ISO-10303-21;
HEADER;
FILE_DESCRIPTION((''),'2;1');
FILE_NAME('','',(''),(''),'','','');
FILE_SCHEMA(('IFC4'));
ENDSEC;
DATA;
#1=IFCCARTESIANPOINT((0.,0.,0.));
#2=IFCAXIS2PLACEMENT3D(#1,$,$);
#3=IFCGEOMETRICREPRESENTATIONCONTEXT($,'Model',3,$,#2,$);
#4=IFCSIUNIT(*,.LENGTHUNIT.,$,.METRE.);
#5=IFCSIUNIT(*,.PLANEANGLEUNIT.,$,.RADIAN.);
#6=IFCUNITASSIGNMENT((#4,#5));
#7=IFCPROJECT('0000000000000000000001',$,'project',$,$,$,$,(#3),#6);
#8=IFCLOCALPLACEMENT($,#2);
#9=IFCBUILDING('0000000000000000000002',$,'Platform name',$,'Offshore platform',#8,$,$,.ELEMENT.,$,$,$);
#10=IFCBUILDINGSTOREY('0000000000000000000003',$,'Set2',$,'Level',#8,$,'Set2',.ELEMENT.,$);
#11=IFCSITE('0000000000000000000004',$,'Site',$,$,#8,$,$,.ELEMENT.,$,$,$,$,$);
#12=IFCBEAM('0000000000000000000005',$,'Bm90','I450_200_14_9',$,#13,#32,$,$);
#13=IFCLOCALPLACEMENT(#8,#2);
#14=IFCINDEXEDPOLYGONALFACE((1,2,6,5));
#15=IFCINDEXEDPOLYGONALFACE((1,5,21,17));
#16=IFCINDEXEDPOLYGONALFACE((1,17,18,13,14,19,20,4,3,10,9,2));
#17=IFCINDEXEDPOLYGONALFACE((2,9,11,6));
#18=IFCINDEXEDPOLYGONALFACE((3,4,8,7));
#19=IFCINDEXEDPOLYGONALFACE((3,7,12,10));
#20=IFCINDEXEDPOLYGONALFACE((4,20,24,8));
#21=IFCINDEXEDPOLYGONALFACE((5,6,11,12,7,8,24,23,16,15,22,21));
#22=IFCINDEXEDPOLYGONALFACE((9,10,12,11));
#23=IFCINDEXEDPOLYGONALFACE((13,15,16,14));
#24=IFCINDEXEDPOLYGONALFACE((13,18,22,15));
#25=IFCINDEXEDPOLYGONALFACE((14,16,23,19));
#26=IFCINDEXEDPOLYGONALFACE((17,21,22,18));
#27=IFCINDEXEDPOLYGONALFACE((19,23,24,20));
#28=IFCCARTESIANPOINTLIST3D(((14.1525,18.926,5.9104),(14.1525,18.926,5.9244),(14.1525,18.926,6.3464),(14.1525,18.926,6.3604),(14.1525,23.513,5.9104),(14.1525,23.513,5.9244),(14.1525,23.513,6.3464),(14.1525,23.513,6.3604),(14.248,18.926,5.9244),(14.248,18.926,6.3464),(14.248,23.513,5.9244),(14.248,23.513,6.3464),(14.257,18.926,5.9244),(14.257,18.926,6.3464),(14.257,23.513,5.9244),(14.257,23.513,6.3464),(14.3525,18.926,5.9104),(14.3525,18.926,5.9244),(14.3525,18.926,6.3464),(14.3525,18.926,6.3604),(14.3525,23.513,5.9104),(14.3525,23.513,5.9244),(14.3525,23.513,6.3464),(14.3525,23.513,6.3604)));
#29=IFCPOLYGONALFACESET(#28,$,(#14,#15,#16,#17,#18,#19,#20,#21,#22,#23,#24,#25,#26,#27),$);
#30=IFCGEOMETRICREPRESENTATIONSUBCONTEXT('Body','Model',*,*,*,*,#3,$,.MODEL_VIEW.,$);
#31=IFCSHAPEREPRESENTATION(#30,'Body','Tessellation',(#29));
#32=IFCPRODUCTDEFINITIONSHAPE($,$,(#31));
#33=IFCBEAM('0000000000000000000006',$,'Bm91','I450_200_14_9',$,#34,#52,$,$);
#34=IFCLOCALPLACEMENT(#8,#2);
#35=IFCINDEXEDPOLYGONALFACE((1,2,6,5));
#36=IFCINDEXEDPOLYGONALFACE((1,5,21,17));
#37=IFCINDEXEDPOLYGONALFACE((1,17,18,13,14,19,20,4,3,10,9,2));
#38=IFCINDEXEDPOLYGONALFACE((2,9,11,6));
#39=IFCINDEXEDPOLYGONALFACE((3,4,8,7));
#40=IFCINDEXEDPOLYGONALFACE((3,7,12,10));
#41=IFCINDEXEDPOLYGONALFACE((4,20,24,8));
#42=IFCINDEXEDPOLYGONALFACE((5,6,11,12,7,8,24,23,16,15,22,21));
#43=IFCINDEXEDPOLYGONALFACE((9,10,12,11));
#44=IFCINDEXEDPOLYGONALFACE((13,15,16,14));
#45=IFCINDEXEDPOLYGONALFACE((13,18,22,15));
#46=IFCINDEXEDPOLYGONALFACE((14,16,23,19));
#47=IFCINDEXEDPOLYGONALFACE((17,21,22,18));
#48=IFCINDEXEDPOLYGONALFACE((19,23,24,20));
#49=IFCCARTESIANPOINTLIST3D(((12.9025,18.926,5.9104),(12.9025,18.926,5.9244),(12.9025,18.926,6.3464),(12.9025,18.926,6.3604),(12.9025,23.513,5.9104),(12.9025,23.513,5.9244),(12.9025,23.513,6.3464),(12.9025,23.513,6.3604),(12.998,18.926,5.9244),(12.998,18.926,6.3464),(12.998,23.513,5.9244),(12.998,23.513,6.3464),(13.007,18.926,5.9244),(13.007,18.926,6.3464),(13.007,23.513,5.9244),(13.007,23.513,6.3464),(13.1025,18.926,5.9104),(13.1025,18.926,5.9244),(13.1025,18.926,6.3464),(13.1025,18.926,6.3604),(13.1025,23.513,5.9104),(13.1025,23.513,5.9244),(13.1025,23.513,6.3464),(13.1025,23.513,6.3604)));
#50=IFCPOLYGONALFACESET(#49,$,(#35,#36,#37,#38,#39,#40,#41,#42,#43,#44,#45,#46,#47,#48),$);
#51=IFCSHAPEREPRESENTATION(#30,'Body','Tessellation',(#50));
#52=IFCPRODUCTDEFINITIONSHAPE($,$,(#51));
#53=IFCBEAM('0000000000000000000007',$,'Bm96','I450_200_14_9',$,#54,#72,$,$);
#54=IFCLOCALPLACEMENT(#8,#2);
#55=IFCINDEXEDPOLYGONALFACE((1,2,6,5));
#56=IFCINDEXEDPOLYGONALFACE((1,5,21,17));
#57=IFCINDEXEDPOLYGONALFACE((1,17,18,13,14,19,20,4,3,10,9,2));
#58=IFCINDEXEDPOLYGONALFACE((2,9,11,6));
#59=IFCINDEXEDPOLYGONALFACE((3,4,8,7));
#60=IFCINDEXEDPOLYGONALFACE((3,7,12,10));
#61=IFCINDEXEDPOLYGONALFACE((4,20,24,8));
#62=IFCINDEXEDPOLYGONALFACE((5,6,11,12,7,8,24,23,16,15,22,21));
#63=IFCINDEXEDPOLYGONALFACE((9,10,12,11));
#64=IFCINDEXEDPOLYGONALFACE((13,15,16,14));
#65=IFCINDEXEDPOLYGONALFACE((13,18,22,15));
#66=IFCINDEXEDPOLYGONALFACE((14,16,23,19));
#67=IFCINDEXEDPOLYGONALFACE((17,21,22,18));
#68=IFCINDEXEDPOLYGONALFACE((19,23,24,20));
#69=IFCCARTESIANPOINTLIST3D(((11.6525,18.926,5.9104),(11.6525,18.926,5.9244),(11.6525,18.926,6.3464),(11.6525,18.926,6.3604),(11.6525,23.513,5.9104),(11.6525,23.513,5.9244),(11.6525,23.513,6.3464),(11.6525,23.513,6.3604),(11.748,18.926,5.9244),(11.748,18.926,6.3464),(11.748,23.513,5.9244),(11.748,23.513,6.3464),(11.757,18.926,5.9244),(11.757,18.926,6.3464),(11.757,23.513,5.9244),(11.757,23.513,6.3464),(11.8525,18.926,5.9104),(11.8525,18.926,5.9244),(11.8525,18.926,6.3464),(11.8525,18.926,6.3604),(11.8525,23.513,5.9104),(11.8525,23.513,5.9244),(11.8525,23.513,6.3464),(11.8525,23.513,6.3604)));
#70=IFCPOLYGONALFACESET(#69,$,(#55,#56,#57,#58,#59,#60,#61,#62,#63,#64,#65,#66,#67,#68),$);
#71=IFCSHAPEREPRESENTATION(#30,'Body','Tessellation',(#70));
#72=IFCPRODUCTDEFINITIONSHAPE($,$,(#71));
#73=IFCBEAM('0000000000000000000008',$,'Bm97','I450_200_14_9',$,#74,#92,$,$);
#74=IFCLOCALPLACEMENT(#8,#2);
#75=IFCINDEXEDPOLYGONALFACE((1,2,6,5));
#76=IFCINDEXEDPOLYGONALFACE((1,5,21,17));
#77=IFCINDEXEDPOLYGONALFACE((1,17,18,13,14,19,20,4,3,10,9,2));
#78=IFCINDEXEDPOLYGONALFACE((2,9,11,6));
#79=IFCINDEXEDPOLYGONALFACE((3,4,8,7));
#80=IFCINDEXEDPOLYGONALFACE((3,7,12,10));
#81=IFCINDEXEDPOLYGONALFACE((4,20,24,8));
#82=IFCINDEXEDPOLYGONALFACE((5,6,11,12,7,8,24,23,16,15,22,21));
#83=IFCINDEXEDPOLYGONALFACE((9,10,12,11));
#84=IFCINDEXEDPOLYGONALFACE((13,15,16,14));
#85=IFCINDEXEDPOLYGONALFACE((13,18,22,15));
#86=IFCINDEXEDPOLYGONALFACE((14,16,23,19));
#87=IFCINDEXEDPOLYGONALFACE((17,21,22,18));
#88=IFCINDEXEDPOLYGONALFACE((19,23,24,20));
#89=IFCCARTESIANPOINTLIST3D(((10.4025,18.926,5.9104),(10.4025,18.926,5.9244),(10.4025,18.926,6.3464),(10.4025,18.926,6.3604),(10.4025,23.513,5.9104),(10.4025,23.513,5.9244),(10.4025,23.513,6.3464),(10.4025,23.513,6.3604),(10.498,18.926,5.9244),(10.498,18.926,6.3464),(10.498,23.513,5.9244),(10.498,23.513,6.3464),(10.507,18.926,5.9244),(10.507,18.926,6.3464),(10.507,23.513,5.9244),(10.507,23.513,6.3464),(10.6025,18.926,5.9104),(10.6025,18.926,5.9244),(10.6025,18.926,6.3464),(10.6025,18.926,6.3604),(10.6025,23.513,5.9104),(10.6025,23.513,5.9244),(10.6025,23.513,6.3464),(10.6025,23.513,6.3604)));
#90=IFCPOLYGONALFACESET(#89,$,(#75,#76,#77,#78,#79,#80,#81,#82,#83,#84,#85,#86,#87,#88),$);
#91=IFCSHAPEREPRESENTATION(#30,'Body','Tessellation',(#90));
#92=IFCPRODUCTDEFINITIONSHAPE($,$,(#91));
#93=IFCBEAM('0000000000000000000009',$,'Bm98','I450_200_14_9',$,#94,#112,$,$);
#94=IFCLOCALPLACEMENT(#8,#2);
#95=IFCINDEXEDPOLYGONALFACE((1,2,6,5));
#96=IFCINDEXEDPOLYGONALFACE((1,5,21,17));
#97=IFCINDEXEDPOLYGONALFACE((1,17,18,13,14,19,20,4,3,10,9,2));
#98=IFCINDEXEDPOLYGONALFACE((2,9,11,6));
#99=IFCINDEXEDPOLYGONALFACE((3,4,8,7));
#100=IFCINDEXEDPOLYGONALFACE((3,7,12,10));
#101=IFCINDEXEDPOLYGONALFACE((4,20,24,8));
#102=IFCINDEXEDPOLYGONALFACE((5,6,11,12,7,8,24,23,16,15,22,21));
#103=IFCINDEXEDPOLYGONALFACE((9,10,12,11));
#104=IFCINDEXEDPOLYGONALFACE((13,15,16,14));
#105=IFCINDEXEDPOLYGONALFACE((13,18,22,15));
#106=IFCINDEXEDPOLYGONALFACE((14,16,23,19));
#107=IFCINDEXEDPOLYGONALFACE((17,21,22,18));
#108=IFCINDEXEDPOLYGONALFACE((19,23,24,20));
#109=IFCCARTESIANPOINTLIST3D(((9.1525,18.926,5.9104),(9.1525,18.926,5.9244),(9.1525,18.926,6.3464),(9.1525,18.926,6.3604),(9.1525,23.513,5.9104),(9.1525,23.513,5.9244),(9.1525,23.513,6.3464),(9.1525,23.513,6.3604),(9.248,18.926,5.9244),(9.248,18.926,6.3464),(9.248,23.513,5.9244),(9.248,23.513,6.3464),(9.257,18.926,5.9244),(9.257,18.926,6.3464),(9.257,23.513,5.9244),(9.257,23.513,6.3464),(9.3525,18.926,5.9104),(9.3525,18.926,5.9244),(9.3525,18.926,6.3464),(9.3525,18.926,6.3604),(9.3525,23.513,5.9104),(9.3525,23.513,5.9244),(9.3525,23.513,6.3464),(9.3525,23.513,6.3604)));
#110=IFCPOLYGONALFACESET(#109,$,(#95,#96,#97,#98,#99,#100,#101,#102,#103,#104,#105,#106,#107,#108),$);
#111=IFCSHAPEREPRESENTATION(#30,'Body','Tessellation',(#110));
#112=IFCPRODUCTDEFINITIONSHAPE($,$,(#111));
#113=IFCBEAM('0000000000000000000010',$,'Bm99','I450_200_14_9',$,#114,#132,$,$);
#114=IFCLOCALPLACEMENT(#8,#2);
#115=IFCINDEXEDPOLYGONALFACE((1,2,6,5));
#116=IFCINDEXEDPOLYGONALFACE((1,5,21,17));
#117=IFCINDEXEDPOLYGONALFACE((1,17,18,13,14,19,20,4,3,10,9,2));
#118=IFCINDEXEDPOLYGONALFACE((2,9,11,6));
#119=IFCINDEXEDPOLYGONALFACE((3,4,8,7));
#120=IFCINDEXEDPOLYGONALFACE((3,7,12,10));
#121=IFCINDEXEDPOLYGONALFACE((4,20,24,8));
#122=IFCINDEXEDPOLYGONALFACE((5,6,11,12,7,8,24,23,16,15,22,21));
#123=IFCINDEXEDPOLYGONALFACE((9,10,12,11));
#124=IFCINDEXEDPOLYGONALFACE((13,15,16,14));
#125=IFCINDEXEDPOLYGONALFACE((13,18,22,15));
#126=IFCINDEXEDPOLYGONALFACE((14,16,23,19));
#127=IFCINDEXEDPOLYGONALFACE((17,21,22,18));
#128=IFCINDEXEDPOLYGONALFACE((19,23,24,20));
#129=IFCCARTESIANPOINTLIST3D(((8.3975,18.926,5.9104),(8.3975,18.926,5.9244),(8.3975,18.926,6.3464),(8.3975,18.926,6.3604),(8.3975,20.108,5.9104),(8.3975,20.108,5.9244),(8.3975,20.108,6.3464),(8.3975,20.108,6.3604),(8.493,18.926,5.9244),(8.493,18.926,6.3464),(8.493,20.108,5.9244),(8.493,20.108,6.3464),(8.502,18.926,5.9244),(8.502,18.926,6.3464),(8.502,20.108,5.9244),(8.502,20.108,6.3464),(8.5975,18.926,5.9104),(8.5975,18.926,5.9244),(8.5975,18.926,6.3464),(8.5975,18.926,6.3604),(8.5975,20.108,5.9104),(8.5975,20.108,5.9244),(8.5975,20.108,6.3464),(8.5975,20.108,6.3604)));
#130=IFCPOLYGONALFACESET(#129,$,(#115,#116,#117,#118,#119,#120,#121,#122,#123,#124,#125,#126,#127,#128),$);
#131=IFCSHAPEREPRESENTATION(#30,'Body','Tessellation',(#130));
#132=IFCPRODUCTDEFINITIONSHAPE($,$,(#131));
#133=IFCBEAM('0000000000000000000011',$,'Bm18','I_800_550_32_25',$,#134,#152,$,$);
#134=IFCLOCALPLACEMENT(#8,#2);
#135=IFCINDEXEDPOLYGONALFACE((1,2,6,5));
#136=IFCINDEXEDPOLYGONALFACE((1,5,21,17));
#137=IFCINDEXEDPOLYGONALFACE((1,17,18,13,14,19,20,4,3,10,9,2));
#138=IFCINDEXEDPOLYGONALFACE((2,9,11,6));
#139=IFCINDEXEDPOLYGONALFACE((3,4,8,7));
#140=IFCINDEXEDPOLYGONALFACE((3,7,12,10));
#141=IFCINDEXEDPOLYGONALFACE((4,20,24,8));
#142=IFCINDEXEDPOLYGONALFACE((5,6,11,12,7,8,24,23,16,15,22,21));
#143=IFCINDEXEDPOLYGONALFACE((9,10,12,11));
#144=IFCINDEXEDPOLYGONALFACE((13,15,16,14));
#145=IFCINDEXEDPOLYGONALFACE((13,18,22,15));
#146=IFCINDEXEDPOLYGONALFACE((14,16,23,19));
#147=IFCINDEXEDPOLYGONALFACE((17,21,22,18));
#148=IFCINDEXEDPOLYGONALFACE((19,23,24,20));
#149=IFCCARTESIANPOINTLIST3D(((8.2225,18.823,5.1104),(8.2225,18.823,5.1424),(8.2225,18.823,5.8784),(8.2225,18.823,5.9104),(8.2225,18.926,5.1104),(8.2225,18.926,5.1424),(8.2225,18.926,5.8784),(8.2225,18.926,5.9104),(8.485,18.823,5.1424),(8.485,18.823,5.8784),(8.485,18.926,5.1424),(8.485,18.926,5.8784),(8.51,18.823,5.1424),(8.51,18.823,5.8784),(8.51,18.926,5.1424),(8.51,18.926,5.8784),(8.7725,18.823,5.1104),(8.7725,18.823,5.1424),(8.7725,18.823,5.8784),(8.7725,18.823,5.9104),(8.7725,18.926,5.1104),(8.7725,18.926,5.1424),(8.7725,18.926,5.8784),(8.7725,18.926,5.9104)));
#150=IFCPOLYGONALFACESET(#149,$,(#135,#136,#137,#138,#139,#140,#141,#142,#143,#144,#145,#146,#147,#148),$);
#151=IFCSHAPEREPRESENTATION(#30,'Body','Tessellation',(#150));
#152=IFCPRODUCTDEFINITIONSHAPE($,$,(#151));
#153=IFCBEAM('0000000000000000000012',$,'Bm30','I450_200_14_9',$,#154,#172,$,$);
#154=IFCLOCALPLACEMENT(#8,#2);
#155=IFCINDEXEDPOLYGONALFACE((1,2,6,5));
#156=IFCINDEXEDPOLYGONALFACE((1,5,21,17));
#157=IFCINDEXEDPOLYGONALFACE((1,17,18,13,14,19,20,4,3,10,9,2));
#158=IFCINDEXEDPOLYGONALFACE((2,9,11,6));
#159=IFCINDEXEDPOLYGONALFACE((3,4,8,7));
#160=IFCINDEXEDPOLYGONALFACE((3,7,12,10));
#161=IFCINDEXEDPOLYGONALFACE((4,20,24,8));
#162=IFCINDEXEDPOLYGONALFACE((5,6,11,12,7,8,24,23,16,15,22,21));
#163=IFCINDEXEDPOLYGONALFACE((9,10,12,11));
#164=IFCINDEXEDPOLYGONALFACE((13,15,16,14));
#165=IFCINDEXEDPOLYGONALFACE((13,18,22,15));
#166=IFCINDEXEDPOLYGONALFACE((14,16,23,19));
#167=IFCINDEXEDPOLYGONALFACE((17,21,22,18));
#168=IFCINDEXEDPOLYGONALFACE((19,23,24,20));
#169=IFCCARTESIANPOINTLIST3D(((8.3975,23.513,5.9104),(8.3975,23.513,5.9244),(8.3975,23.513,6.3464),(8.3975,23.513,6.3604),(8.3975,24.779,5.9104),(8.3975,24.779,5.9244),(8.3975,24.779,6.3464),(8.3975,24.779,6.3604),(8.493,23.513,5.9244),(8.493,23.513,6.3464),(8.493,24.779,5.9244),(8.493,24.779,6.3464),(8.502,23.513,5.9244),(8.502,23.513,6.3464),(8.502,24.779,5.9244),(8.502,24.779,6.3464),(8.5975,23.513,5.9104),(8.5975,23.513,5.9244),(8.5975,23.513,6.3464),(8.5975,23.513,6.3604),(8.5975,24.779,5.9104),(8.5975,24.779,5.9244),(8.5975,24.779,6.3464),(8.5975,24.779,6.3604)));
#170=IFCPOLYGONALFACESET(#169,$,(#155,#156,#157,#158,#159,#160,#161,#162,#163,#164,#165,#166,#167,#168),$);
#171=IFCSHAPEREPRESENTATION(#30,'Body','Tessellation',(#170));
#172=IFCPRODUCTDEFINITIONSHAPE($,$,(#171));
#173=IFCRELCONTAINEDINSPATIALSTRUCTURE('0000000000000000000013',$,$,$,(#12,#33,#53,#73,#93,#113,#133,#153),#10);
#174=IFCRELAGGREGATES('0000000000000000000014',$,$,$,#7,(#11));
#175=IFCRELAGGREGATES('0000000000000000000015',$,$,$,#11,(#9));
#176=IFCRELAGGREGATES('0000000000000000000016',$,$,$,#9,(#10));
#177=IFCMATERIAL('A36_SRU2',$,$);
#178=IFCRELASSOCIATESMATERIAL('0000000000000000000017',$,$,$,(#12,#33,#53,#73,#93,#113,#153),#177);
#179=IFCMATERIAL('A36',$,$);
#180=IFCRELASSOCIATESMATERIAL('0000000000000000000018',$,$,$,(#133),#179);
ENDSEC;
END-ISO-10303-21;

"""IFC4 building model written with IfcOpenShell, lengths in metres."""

from ifc_helpers import new_model, si_unit, frame, origin, origin_2d, place, context, subcontext, project, spatial, i_section, extrude, source, transform, mapped, material, element, save


model = new_model("IFC4")

# Units and contexts
model_context = context("Model", 3, world=origin())
body_context = subcontext(model_context, "Body", "Model", "MODEL_VIEW")
ifc_project = project(units=[si_unit("LENGTHUNIT", "METRE"), si_unit("PLANEANGLEUNIT", "RADIAN")], contexts=[model_context])

# Site, building, storey
placement_1 = place(None, origin())
site = spatial("IfcSite", under=ifc_project, at=placement_1, Name="Site", CompositionType="ELEMENT")
building = spatial("IfcBuilding", under=site, at=placement_1, Name="Platform name", ObjectType="Offshore platform", CompositionType="ELEMENT")
storey = spatial("IfcBuildingStorey", under=building, at=placement_1, Name="Set2", ObjectType="Level", LongName="Set2", CompositionType="ELEMENT")

# Beams
ifc_material_1 = material(Name="A36_SRU2")
shared_shape_1 = source(origin(), body_context, "Body", "SweptSolid", [
    extrude(i_section(OverallWidth=0.2, OverallDepth=0.45, WebThickness=0.009, FlangeThickness=0.014, FilletRadius=0.0, at=origin_2d()), frame((0.0, 0.0, 0.0), z_axis=(0.0, 1.0, 0.0), x_axis=(-1.0, 0.0, 0.0)), (0.0, 0.0, 1.0), 4.587),
])
placement_2 = place(None, origin())
placement_3 = place(placement_2, origin())
placement_4 = place(placement_3, origin())
beam_1_placement = place(placement_4, frame((14.2525, 18.926, 6.1354)))
element("IfcBeam", 1, at=beam_1_placement, inside=storey, material=ifc_material_1, Name="Bm90", Description="I450_200_14_9", context=body_context, shape_type="MappedRepresentation", body=[
    mapped(shared_shape_1, transform((0.0, 0.0, 0.0), scale=1.0)),
])
shared_shape_2 = source(origin(), body_context, "Body", "SweptSolid", [
    extrude(i_section(OverallWidth=0.2, OverallDepth=0.45, WebThickness=0.009, FlangeThickness=0.014, FilletRadius=0.0, at=origin_2d()), frame((0.0, 0.0, 0.0), z_axis=(0.0, 1.0, 0.0), x_axis=(-1.0, 0.0, 0.0)), (0.0, 0.0, 1.0), 4.587),
])
placement_5 = place(None, origin())
placement_6 = place(placement_5, origin())
placement_7 = place(placement_6, origin())
beam_2_placement = place(placement_7, frame((13.0025, 18.926, 6.1354)))
element("IfcBeam", 2, at=beam_2_placement, inside=storey, material=ifc_material_1, Name="Bm91", Description="I450_200_14_9", context=body_context, shape_type="MappedRepresentation", body=[
    mapped(shared_shape_2, transform((0.0, 0.0, 0.0), scale=1.0)),
])
shared_shape_3 = source(origin(), body_context, "Body", "SweptSolid", [
    extrude(i_section(OverallWidth=0.2, OverallDepth=0.45, WebThickness=0.009, FlangeThickness=0.014, FilletRadius=0.0, at=origin_2d()), frame((0.0, 0.0, 0.0), z_axis=(0.0, 1.0, 0.0), x_axis=(-1.0, 0.0, 0.0)), (0.0, 0.0, 1.0), 4.587),
])
placement_8 = place(None, origin())
placement_9 = place(placement_8, origin())
placement_10 = place(placement_9, origin())
beam_3_placement = place(placement_10, frame((11.7525, 18.926, 6.1354)))
element("IfcBeam", 3, at=beam_3_placement, inside=storey, material=ifc_material_1, Name="Bm96", Description="I450_200_14_9", context=body_context, shape_type="MappedRepresentation", body=[
    mapped(shared_shape_3, transform((0.0, 0.0, 0.0), scale=1.0)),
])
shared_shape_4 = source(origin(), body_context, "Body", "SweptSolid", [
    extrude(i_section(OverallWidth=0.2, OverallDepth=0.45, WebThickness=0.009, FlangeThickness=0.014, FilletRadius=0.0, at=origin_2d()), frame((0.0, 0.0, 0.0), z_axis=(0.0, 1.0, 0.0), x_axis=(-1.0, 0.0, 0.0)), (0.0, 0.0, 1.0), 4.587),
])
placement_11 = place(None, origin())
placement_12 = place(placement_11, origin())
placement_13 = place(placement_12, origin())
beam_4_placement = place(placement_13, frame((10.5025, 18.926, 6.1354)))
element("IfcBeam", 4, at=beam_4_placement, inside=storey, material=ifc_material_1, Name="Bm97", Description="I450_200_14_9", context=body_context, shape_type="MappedRepresentation", body=[
    mapped(shared_shape_4, transform((0.0, 0.0, 0.0), scale=1.0)),
])
shared_shape_5 = source(origin(), body_context, "Body", "SweptSolid", [
    extrude(i_section(OverallWidth=0.2, OverallDepth=0.45, WebThickness=0.009, FlangeThickness=0.014, FilletRadius=0.0, at=origin_2d()), frame((0.0, 0.0, 0.0), z_axis=(0.0, 1.0, 0.0), x_axis=(-1.0, 0.0, 0.0)), (0.0, 0.0, 1.0), 4.587),
])
placement_14 = place(None, origin())
placement_15 = place(placement_14, origin())
placement_16 = place(placement_15, origin())
beam_5_placement = place(placement_16, frame((9.2525, 18.926, 6.1354)))
element("IfcBeam", 5, at=beam_5_placement, inside=storey, material=ifc_material_1, Name="Bm98", Description="I450_200_14_9", context=body_context, shape_type="MappedRepresentation", body=[
    mapped(shared_shape_5, transform((0.0, 0.0, 0.0), scale=1.0)),
])
shared_shape_6 = source(origin(), body_context, "Body", "SweptSolid", [
    extrude(i_section(OverallWidth=0.2, OverallDepth=0.45, WebThickness=0.009, FlangeThickness=0.014, FilletRadius=0.0, at=origin_2d()), frame((0.0, 0.0, 0.0), z_axis=(0.0, 1.0, 0.0), x_axis=(-1.0, 0.0, 0.0)), (0.0, 0.0, 1.0), 1.182),
])
placement_17 = place(None, origin())
placement_18 = place(placement_17, origin())
placement_19 = place(placement_18, origin())
beam_6_placement = place(placement_19, frame((8.4975, 18.926, 6.1354)))
element("IfcBeam", 6, at=beam_6_placement, inside=storey, material=ifc_material_1, Name="Bm99", Description="I450_200_14_9", context=body_context, shape_type="MappedRepresentation", body=[
    mapped(shared_shape_6, transform((0.0, 0.0, 0.0), scale=1.0)),
])
ifc_material_2 = material(Name="A36")
shared_shape_7 = source(origin(), body_context, "Body", "SweptSolid", [
    extrude(i_section(OverallWidth=0.55, OverallDepth=0.8, WebThickness=0.025, FlangeThickness=0.032, FilletRadius=0.0, at=origin_2d()), frame((0.0, 0.0, 0.0), z_axis=(0.0, -1.0, 0.0), x_axis=(1.0, 0.0, 0.0)), (0.0, 0.0, 1.0), 0.103),
])
placement_20 = place(None, origin())
placement_21 = place(placement_20, origin())
placement_22 = place(placement_21, origin())
beam_7_placement = place(placement_22, frame((8.4975, 18.926, 5.5104)))
element("IfcBeam", 7, at=beam_7_placement, inside=storey, material=ifc_material_2, Name="Bm18", Description="I_800_550_32_25", context=body_context, shape_type="MappedRepresentation", body=[
    mapped(shared_shape_7, transform((0.0, 0.0, 0.0), scale=1.0)),
])
shared_shape_8 = source(origin(), body_context, "Body", "SweptSolid", [
    extrude(i_section(OverallWidth=0.2, OverallDepth=0.45, WebThickness=0.009, FlangeThickness=0.014, FilletRadius=0.0, at=origin_2d()), frame((0.0, 0.0, 0.0), z_axis=(0.0, 1.0, 0.0), x_axis=(-1.0, 0.0, 0.0)), (0.0, 0.0, 1.0), 1.266),
])
placement_23 = place(None, origin())
placement_24 = place(placement_23, origin())
placement_25 = place(placement_24, origin())
beam_8_placement = place(placement_25, frame((8.4975, 23.513, 6.1354)))
element("IfcBeam", 8, at=beam_8_placement, inside=storey, material=ifc_material_1, Name="Bm30", Description="I450_200_14_9", context=body_context, shape_type="MappedRepresentation", body=[
    mapped(shared_shape_8, transform((0.0, 0.0, 0.0), scale=1.0)),
])

save(model, "model.ifc")
